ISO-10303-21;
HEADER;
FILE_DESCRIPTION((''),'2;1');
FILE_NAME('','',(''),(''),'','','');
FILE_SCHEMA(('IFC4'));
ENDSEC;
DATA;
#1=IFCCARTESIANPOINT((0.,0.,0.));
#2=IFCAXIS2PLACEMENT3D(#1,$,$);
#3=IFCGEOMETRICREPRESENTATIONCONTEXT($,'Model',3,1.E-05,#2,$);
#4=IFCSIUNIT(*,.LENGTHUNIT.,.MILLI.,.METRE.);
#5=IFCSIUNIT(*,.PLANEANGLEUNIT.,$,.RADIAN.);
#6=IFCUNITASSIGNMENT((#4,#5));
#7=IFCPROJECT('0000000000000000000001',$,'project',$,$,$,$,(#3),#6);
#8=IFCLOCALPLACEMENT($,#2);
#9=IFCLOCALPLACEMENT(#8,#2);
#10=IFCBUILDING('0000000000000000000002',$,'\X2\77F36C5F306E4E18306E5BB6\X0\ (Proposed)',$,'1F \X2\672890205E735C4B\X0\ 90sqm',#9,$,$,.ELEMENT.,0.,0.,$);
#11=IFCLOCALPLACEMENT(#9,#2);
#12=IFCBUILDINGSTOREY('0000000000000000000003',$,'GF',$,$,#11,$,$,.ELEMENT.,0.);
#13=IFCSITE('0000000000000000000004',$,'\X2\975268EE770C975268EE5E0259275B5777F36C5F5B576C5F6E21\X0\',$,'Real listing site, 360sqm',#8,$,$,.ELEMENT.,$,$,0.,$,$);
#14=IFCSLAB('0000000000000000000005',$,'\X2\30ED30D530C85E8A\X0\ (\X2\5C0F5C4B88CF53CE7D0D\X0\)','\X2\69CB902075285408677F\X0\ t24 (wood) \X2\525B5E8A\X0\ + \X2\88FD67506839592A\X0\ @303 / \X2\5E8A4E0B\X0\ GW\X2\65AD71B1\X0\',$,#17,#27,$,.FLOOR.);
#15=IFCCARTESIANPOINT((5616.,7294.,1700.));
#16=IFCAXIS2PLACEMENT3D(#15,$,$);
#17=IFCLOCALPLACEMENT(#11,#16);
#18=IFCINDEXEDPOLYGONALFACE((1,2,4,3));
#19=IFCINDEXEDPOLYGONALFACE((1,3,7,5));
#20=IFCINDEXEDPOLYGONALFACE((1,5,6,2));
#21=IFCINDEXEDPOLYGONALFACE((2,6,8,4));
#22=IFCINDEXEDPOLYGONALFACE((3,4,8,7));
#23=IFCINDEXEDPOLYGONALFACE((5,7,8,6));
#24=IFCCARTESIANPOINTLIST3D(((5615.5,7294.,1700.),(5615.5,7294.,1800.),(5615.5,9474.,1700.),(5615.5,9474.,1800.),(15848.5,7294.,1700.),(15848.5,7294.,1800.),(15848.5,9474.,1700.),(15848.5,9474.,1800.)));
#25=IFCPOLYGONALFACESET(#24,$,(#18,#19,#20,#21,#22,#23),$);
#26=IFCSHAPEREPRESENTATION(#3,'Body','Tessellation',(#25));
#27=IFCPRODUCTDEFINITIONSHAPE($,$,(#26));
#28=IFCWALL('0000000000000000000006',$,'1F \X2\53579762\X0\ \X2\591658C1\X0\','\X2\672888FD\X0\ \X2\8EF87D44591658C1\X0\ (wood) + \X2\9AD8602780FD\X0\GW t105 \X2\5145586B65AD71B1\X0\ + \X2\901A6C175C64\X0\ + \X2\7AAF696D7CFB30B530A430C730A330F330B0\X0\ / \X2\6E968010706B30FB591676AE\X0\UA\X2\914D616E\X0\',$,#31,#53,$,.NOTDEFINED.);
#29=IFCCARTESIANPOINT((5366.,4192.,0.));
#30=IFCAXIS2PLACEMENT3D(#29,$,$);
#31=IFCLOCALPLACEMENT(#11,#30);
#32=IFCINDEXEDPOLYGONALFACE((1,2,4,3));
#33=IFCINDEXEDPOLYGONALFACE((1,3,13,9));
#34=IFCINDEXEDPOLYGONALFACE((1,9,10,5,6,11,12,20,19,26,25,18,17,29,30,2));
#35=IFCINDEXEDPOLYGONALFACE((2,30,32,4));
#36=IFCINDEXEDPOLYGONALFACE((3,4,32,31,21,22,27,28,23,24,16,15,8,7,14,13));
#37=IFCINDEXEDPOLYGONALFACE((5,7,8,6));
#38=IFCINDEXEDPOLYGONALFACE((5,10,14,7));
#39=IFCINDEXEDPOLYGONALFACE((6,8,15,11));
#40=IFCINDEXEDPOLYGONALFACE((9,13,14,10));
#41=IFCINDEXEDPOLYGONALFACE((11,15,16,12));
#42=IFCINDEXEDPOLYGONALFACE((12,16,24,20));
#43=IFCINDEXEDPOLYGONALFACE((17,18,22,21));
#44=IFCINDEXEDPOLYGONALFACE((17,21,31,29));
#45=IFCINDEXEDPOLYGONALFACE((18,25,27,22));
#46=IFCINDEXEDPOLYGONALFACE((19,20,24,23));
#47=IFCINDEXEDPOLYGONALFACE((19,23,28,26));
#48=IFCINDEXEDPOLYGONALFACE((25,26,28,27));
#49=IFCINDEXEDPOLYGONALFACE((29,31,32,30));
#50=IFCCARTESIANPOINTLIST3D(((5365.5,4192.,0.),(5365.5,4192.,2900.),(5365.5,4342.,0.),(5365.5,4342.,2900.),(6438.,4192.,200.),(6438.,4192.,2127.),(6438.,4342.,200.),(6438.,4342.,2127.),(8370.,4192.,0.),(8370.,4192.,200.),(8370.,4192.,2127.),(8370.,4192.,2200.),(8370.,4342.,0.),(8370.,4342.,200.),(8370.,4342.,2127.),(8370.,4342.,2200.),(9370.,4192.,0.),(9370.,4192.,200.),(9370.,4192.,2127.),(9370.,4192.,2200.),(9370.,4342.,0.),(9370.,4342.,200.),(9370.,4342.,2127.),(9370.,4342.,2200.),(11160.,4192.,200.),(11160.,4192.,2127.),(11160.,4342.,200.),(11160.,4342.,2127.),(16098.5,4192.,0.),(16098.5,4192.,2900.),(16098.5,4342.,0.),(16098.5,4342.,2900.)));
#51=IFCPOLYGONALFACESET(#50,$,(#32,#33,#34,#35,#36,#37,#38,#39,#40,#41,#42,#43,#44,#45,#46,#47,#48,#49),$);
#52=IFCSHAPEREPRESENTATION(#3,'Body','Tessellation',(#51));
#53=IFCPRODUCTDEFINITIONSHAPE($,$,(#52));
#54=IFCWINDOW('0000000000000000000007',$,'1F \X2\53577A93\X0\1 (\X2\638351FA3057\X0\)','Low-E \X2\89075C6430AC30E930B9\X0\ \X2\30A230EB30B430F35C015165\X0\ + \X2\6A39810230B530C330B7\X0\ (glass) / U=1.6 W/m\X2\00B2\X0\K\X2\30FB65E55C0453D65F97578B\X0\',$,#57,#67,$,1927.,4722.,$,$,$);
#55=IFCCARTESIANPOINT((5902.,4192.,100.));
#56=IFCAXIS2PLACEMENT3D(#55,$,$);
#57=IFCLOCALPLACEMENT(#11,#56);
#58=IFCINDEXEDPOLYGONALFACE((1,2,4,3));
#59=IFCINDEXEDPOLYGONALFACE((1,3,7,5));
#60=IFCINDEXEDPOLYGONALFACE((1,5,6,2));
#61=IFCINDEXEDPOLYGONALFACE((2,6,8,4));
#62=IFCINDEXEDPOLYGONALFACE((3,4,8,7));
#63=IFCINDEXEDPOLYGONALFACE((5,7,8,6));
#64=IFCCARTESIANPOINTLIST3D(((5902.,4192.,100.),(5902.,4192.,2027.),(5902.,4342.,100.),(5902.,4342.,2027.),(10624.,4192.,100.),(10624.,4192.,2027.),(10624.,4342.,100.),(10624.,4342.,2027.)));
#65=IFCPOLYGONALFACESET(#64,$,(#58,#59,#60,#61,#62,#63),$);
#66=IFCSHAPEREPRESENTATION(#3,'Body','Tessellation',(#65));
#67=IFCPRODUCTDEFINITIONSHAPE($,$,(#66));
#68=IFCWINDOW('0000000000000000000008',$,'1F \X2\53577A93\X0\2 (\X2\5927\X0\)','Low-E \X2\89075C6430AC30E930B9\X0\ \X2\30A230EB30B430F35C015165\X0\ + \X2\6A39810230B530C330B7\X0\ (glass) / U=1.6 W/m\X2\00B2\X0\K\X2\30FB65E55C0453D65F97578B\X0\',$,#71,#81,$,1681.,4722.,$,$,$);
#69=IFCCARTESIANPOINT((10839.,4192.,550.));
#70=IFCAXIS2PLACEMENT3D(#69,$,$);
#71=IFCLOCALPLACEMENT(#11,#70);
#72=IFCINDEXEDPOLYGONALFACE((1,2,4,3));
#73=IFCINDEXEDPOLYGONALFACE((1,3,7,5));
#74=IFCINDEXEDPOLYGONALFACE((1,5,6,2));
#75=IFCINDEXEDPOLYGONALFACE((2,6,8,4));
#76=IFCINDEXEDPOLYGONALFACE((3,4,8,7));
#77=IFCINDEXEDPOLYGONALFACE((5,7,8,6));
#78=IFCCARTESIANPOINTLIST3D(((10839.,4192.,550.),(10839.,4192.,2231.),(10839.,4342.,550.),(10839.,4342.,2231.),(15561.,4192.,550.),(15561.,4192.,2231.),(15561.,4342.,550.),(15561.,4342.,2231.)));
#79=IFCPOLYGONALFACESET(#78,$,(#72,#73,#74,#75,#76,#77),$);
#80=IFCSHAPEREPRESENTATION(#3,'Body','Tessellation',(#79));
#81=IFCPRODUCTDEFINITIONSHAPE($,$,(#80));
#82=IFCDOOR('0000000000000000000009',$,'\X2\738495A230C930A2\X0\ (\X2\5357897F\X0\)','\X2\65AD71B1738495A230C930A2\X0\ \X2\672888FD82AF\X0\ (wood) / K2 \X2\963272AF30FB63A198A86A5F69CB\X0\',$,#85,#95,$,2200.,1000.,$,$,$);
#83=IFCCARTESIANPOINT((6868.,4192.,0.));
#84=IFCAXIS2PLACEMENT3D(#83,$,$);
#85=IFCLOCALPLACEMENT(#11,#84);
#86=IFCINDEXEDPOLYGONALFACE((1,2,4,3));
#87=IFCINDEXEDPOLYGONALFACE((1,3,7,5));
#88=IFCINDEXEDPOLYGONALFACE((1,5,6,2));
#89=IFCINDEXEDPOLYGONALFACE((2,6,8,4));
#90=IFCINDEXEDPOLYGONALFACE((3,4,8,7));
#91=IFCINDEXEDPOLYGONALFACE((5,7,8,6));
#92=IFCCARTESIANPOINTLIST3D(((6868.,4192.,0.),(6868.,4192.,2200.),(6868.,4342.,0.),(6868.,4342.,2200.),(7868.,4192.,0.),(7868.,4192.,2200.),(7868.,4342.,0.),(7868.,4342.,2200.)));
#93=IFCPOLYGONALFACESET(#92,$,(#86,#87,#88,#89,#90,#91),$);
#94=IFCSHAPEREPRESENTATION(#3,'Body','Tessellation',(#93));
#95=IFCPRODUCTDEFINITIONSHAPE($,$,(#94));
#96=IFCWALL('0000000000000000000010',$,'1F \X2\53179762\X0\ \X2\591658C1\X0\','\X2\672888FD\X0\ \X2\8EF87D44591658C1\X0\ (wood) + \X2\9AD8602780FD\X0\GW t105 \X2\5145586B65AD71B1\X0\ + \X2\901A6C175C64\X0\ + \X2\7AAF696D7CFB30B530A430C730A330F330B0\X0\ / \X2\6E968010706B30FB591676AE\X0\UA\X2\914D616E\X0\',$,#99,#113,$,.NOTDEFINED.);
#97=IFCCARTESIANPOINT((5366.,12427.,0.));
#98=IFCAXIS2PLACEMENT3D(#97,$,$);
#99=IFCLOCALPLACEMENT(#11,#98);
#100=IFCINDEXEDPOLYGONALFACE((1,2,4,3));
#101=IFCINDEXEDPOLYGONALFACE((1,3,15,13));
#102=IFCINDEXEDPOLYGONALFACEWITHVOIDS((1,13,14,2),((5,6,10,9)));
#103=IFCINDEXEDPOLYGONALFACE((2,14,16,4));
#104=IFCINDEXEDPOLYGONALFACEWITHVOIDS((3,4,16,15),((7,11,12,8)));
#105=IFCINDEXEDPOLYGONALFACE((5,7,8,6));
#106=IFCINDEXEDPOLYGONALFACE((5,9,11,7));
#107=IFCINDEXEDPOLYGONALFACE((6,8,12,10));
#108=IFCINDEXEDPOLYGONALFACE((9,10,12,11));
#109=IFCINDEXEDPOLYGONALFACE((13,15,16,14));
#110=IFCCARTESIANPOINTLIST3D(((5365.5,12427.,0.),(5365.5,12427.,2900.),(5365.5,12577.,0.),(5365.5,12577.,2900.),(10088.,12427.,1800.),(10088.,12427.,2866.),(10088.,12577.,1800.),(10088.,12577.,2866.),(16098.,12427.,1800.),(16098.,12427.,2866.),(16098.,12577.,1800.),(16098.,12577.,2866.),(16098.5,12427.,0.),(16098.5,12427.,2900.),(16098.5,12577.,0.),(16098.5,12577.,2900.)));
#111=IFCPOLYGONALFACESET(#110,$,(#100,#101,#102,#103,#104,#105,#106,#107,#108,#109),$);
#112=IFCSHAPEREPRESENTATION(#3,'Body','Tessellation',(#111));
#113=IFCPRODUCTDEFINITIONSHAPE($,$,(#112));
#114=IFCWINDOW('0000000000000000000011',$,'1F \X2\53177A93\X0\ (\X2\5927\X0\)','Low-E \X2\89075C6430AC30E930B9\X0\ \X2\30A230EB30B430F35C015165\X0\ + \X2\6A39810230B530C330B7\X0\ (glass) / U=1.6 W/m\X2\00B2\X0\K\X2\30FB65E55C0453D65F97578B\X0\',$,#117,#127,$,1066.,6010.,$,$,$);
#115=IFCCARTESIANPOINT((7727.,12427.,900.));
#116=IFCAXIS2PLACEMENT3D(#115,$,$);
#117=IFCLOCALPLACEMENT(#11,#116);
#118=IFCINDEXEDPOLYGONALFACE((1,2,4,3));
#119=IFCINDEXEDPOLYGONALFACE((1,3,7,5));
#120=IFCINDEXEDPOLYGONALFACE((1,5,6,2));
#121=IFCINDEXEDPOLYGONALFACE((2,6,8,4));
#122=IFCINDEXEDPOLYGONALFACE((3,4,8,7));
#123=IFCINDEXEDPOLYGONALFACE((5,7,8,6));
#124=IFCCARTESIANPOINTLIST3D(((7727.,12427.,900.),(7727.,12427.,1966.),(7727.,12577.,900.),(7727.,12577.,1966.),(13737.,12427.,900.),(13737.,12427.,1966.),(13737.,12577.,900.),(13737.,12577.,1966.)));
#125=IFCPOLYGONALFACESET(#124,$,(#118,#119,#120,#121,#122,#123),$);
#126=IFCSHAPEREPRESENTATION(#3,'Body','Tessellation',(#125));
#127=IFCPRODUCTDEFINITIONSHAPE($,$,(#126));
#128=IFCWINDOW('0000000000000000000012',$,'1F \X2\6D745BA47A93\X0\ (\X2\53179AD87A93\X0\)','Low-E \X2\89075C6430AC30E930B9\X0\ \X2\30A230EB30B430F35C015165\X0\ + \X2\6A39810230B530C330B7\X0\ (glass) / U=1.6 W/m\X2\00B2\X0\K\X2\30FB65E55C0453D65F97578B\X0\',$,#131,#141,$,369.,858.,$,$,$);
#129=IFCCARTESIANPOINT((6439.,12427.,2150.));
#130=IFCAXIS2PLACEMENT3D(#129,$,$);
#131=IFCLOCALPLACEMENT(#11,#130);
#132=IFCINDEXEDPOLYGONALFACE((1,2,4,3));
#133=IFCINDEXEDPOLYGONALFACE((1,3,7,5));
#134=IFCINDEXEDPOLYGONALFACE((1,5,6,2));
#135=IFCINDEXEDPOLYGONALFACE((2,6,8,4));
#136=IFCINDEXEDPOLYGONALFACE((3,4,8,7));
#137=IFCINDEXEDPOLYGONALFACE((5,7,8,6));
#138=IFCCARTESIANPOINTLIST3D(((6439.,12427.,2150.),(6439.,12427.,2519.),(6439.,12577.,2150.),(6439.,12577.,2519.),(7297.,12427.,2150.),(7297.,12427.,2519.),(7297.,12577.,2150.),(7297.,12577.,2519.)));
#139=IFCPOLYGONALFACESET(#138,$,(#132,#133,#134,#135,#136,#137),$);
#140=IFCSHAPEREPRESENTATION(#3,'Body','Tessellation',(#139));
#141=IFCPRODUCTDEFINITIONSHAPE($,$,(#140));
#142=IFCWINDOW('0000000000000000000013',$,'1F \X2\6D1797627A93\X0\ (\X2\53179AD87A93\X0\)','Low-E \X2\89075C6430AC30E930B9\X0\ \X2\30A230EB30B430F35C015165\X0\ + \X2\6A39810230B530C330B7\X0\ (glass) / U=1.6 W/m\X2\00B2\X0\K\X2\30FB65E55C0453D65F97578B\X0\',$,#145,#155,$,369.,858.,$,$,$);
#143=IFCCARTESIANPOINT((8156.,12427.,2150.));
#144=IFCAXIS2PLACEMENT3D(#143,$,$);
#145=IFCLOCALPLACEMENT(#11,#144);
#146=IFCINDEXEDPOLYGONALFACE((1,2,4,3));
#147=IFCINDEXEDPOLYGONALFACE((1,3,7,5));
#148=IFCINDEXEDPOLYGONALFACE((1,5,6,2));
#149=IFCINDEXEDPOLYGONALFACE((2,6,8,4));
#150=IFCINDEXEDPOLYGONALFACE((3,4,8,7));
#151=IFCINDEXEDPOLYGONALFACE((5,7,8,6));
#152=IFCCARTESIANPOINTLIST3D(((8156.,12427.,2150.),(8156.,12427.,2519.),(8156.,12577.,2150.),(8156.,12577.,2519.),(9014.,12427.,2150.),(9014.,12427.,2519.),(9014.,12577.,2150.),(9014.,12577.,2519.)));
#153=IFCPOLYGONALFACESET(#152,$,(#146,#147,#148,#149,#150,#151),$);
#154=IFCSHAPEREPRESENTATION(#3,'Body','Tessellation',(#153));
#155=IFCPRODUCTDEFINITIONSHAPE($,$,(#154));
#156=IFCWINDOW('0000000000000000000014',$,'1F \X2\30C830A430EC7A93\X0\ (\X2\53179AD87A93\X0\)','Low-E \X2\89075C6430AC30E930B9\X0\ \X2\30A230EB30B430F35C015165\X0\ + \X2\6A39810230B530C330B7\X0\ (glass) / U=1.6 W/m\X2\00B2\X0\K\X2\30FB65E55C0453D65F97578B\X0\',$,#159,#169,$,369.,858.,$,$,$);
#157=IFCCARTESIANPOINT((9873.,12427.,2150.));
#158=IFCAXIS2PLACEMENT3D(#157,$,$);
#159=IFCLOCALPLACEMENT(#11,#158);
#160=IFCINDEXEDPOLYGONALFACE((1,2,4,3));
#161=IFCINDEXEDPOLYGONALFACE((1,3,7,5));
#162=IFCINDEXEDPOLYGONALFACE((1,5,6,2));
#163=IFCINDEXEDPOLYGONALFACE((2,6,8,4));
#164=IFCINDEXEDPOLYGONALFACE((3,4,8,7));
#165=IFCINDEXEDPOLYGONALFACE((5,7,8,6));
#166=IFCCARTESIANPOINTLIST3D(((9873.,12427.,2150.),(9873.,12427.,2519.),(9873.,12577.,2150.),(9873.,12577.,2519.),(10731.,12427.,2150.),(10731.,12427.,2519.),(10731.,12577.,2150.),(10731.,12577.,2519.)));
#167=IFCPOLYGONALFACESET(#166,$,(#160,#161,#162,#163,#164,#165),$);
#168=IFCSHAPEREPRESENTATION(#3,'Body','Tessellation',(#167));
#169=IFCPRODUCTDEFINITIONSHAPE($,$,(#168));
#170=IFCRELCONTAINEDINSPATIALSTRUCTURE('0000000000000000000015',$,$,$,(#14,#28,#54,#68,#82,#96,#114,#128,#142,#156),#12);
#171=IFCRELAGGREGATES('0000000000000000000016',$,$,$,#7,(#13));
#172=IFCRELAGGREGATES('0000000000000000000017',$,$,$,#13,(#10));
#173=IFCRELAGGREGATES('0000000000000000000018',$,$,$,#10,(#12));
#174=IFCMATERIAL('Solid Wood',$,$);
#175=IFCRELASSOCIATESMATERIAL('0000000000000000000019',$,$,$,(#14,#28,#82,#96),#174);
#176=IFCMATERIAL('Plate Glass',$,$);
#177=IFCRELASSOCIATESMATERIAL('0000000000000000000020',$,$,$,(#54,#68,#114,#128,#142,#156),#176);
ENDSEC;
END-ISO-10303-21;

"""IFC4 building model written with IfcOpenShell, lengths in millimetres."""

from ifc_helpers import new_model, si_unit, frame, frame_2d, origin, place, context, project, spatial, rectangle, extrude, material, element, fill, save


model = new_model("IFC4")

# Units and contexts
model_context = context("Model", 3, precision=1e-05, world=origin())
ifc_project = project(units=[si_unit("LENGTHUNIT", "METRE", prefix="MILLI"), si_unit("PLANEANGLEUNIT", "RADIAN")], contexts=[model_context])

# Site, building, storey
site_placement = place(None, origin())
site = spatial("IfcSite", under=ifc_project, at=site_placement, Name="青森県青森市大字石江字江渡", ObjectType="Real listing site, 360sqm", CompositionType="ELEMENT", RefElevation=0.0)
building_placement = place(site_placement, origin())
building = spatial("IfcBuilding", under=site, at=building_placement, Name="石江の丘の家 (Proposed)", ObjectType="1F 木造平屋 90sqm", CompositionType="ELEMENT", ElevationOfRefHeight=0.0, ElevationOfTerrain=0.0)
storey_placement = place(building_placement, origin())
storey = spatial("IfcBuildingStorey", under=building, at=storey_placement, Name="GF", CompositionType="ELEMENT", Elevation=0.0)

# Slab
ifc_material_1 = material(Name="Solid Wood")
slab_1_placement = place(storey_placement, frame((5616.0, 7294.0, 1700.0)))
element("IfcSlab", 1, at=slab_1_placement, inside=storey, material=ifc_material_1, Name="ロフト床 (小屋裏収納)", Description="構造用合板 t24 (wood) 剛床 + 製材根太 @303 / 床下 GW断熱", PredefinedType="FLOOR", context=model_context, shape_type="SweptSolid", body=[
    extrude(rectangle(XDim=10233.0, YDim=2180.0, at=frame_2d((5116.0, 1090.0))), frame((5616.0, 7294.0, 1700.0)), (0.0, 0.0, 1.0), 100.0),
])

# Wall, openings, windows, door
wall_1_placement = place(storey_placement, frame((5366.0, 4192.0, 0.0)))
wall_1 = element("IfcWall", 2, at=wall_1_placement, inside=storey, material=ifc_material_1, Name="1F 南面 外壁", Description="木製 軸組外壁 (wood) + 高性能GW t105 充填断熱 + 通気層 + 窯業系サイディング / 準耐火・外皮UA配慮", PredefinedType="NOTDEFINED", context=model_context, shape_type="SweptSolid", body=[
    extrude(rectangle(XDim=10733.0, YDim=150.0, at=frame_2d((5366.0, 75.0))), frame((5366.0, 4192.0, 0.0)), (0.0, 0.0, 1.0), 2900.0),
])
opening_1_placement = place(storey_placement, frame((5902.0, 4192.0, 100.0)))
opening_1 = element("IfcOpeningElement", 3, at=opening_1_placement, cuts=wall_1, PredefinedType="NOTDEFINED", context=model_context, shape_type="SweptSolid", body=[
    extrude(rectangle(XDim=4722.0, YDim=150.0, at=frame_2d((2361.0, 75.0))), frame((5902.0, 4192.0, 100.0)), (0.0, 0.0, 1.0), 1927.0),
])
opening_2_placement = place(storey_placement, frame((10839.0, 4192.0, 550.0)))
opening_2 = element("IfcOpeningElement", 4, at=opening_2_placement, cuts=wall_1, PredefinedType="NOTDEFINED", context=model_context, shape_type="SweptSolid", body=[
    extrude(rectangle(XDim=4722.0, YDim=150.0, at=frame_2d((2361.0, 75.0))), frame((10839.0, 4192.0, 550.0)), (0.0, 0.0, 1.0), 1681.0),
])
opening_3_placement = place(storey_placement, frame((6868.0, 4192.0, 0.0)))
opening_3 = element("IfcOpeningElement", 5, at=opening_3_placement, cuts=wall_1, PredefinedType="NOTDEFINED", context=model_context, shape_type="SweptSolid", body=[
    extrude(rectangle(XDim=1000.0, YDim=150.0, at=frame_2d((500.0, 75.0))), frame((6868.0, 4192.0, 0.0)), (0.0, 0.0, 1.0), 2200.0),
])
ifc_material_2 = material(Name="Plate Glass")
window_1_placement = place(storey_placement, frame((5902.0, 4192.0, 100.0)))
window_1 = element("IfcWindow", 6, at=window_1_placement, inside=storey, material=ifc_material_2, Name="1F 南窓1 (掃出し)", Description="Low-E 複層ガラス アルゴン封入 + 樹脂サッシ (glass) / U=1.6 W/m²K・日射取得型", OverallHeight=1927.0, OverallWidth=4722.0, context=model_context, shape_type="SweptSolid", body=[
    extrude(rectangle(XDim=4722.0, YDim=150.0, at=frame_2d((2361.0, 75.0))), frame((5902.0, 4192.0, 100.0)), (0.0, 0.0, 1.0), 1927.0),
])
fill(opening_1, window_1)
window_2_placement = place(storey_placement, frame((10839.0, 4192.0, 550.0)))
window_2 = element("IfcWindow", 7, at=window_2_placement, inside=storey, material=ifc_material_2, Name="1F 南窓2 (大)", Description="Low-E 複層ガラス アルゴン封入 + 樹脂サッシ (glass) / U=1.6 W/m²K・日射取得型", OverallHeight=1681.0, OverallWidth=4722.0, context=model_context, shape_type="SweptSolid", body=[
    extrude(rectangle(XDim=4722.0, YDim=150.0, at=frame_2d((2361.0, 75.0))), frame((10839.0, 4192.0, 550.0)), (0.0, 0.0, 1.0), 1681.0),
])
fill(opening_2, window_2)
door_1_placement = place(storey_placement, frame((6868.0, 4192.0, 0.0)))
door_1 = element("IfcDoor", 8, at=door_1_placement, inside=storey, material=ifc_material_1, Name="玄関ドア (南西)", Description="断熱玄関ドア 木製芯 (wood) / K2 防犯・採風機構", OverallHeight=2200.0, OverallWidth=1000.0, context=model_context, shape_type="SweptSolid", body=[
    extrude(rectangle(XDim=1000.0, YDim=150.0, at=frame_2d((500.0, 75.0))), frame((6868.0, 4192.0, 0.0)), (0.0, 0.0, 1.0), 2200.0),
])
fill(opening_3, door_1)

# Wall, openings, windows
wall_2_placement = place(storey_placement, frame((5366.0, 12427.0, 0.0)))
wall_2 = element("IfcWall", 9, at=wall_2_placement, inside=storey, material=ifc_material_1, Name="1F 北面 外壁", Description="木製 軸組外壁 (wood) + 高性能GW t105 充填断熱 + 通気層 + 窯業系サイディング / 準耐火・外皮UA配慮", PredefinedType="NOTDEFINED", context=model_context, shape_type="SweptSolid", body=[
    extrude(rectangle(XDim=10733.0, YDim=150.0, at=frame_2d((5366.0, 75.0))), frame((5366.0, 12427.0, 0.0)), (0.0, 0.0, 1.0), 2900.0),
])
opening_4_placement = place(storey_placement, frame((7727.0, 12427.0, 900.0)))
opening_4 = element("IfcOpeningElement", 10, at=opening_4_placement, cuts=wall_2, PredefinedType="NOTDEFINED", context=model_context, shape_type="SweptSolid", body=[
    extrude(rectangle(XDim=6010.0, YDim=150.0, at=frame_2d((3005.0, 75.0))), frame((7727.0, 12427.0, 900.0)), (0.0, 0.0, 1.0), 1066.0),
])
opening_5_placement = place(storey_placement, frame((6439.0, 12427.0, 2150.0)))
opening_5 = element("IfcOpeningElement", 11, at=opening_5_placement, cuts=wall_2, PredefinedType="NOTDEFINED", context=model_context, shape_type="SweptSolid", body=[
    extrude(rectangle(XDim=858.0, YDim=150.0, at=frame_2d((429.0, 75.0))), frame((6439.0, 12427.0, 2150.0)), (0.0, 0.0, 1.0), 369.0),
])
opening_6_placement = place(storey_placement, frame((8156.0, 12427.0, 2150.0)))
opening_6 = element("IfcOpeningElement", 12, at=opening_6_placement, cuts=wall_2, PredefinedType="NOTDEFINED", context=model_context, shape_type="SweptSolid", body=[
    extrude(rectangle(XDim=858.0, YDim=150.0, at=frame_2d((429.0, 75.0))), frame((8156.0, 12427.0, 2150.0)), (0.0, 0.0, 1.0), 369.0),
])
opening_7_placement = place(storey_placement, frame((9873.0, 12427.0, 2150.0)))
opening_7 = element("IfcOpeningElement", 13, at=opening_7_placement, cuts=wall_2, PredefinedType="NOTDEFINED", context=model_context, shape_type="SweptSolid", body=[
    extrude(rectangle(XDim=858.0, YDim=150.0, at=frame_2d((429.0, 75.0))), frame((9873.0, 12427.0, 2150.0)), (0.0, 0.0, 1.0), 369.0),
])
window_3_placement = place(storey_placement, frame((7727.0, 12427.0, 900.0)))
window_3 = element("IfcWindow", 14, at=window_3_placement, inside=storey, material=ifc_material_2, Name="1F 北窓 (大)", Description="Low-E 複層ガラス アルゴン封入 + 樹脂サッシ (glass) / U=1.6 W/m²K・日射取得型", OverallHeight=1066.0, OverallWidth=6010.0, context=model_context, shape_type="SweptSolid", body=[
    extrude(rectangle(XDim=6010.0, YDim=150.0, at=frame_2d((3005.0, 75.0))), frame((7727.0, 12427.0, 900.0)), (0.0, 0.0, 1.0), 1066.0),
])
fill(opening_4, window_3)
window_4_placement = place(storey_placement, frame((6439.0, 12427.0, 2150.0)))
window_4 = element("IfcWindow", 15, at=window_4_placement, inside=storey, material=ifc_material_2, Name="1F 浴室窓 (北高窓)", Description="Low-E 複層ガラス アルゴン封入 + 樹脂サッシ (glass) / U=1.6 W/m²K・日射取得型", OverallHeight=369.0, OverallWidth=858.0, context=model_context, shape_type="SweptSolid", body=[
    extrude(rectangle(XDim=858.0, YDim=150.0, at=frame_2d((429.0, 75.0))), frame((6439.0, 12427.0, 2150.0)), (0.0, 0.0, 1.0), 369.0),
])
fill(opening_5, window_4)
window_5_placement = place(storey_placement, frame((8156.0, 12427.0, 2150.0)))
window_5 = element("IfcWindow", 16, at=window_5_placement, inside=storey, material=ifc_material_2, Name="1F 洗面窓 (北高窓)", Description="Low-E 複層ガラス アルゴン封入 + 樹脂サッシ (glass) / U=1.6 W/m²K・日射取得型", OverallHeight=369.0, OverallWidth=858.0, context=model_context, shape_type="SweptSolid", body=[
    extrude(rectangle(XDim=858.0, YDim=150.0, at=frame_2d((429.0, 75.0))), frame((8156.0, 12427.0, 2150.0)), (0.0, 0.0, 1.0), 369.0),
])
fill(opening_6, window_5)
window_6_placement = place(storey_placement, frame((9873.0, 12427.0, 2150.0)))
window_6 = element("IfcWindow", 17, at=window_6_placement, inside=storey, material=ifc_material_2, Name="1F トイレ窓 (北高窓)", Description="Low-E 複層ガラス アルゴン封入 + 樹脂サッシ (glass) / U=1.6 W/m²K・日射取得型", OverallHeight=369.0, OverallWidth=858.0, context=model_context, shape_type="SweptSolid", body=[
    extrude(rectangle(XDim=858.0, YDim=150.0, at=frame_2d((429.0, 75.0))), frame((9873.0, 12427.0, 2150.0)), (0.0, 0.0, 1.0), 369.0),
])
fill(opening_7, window_6)

save(model, "model.ifc")
